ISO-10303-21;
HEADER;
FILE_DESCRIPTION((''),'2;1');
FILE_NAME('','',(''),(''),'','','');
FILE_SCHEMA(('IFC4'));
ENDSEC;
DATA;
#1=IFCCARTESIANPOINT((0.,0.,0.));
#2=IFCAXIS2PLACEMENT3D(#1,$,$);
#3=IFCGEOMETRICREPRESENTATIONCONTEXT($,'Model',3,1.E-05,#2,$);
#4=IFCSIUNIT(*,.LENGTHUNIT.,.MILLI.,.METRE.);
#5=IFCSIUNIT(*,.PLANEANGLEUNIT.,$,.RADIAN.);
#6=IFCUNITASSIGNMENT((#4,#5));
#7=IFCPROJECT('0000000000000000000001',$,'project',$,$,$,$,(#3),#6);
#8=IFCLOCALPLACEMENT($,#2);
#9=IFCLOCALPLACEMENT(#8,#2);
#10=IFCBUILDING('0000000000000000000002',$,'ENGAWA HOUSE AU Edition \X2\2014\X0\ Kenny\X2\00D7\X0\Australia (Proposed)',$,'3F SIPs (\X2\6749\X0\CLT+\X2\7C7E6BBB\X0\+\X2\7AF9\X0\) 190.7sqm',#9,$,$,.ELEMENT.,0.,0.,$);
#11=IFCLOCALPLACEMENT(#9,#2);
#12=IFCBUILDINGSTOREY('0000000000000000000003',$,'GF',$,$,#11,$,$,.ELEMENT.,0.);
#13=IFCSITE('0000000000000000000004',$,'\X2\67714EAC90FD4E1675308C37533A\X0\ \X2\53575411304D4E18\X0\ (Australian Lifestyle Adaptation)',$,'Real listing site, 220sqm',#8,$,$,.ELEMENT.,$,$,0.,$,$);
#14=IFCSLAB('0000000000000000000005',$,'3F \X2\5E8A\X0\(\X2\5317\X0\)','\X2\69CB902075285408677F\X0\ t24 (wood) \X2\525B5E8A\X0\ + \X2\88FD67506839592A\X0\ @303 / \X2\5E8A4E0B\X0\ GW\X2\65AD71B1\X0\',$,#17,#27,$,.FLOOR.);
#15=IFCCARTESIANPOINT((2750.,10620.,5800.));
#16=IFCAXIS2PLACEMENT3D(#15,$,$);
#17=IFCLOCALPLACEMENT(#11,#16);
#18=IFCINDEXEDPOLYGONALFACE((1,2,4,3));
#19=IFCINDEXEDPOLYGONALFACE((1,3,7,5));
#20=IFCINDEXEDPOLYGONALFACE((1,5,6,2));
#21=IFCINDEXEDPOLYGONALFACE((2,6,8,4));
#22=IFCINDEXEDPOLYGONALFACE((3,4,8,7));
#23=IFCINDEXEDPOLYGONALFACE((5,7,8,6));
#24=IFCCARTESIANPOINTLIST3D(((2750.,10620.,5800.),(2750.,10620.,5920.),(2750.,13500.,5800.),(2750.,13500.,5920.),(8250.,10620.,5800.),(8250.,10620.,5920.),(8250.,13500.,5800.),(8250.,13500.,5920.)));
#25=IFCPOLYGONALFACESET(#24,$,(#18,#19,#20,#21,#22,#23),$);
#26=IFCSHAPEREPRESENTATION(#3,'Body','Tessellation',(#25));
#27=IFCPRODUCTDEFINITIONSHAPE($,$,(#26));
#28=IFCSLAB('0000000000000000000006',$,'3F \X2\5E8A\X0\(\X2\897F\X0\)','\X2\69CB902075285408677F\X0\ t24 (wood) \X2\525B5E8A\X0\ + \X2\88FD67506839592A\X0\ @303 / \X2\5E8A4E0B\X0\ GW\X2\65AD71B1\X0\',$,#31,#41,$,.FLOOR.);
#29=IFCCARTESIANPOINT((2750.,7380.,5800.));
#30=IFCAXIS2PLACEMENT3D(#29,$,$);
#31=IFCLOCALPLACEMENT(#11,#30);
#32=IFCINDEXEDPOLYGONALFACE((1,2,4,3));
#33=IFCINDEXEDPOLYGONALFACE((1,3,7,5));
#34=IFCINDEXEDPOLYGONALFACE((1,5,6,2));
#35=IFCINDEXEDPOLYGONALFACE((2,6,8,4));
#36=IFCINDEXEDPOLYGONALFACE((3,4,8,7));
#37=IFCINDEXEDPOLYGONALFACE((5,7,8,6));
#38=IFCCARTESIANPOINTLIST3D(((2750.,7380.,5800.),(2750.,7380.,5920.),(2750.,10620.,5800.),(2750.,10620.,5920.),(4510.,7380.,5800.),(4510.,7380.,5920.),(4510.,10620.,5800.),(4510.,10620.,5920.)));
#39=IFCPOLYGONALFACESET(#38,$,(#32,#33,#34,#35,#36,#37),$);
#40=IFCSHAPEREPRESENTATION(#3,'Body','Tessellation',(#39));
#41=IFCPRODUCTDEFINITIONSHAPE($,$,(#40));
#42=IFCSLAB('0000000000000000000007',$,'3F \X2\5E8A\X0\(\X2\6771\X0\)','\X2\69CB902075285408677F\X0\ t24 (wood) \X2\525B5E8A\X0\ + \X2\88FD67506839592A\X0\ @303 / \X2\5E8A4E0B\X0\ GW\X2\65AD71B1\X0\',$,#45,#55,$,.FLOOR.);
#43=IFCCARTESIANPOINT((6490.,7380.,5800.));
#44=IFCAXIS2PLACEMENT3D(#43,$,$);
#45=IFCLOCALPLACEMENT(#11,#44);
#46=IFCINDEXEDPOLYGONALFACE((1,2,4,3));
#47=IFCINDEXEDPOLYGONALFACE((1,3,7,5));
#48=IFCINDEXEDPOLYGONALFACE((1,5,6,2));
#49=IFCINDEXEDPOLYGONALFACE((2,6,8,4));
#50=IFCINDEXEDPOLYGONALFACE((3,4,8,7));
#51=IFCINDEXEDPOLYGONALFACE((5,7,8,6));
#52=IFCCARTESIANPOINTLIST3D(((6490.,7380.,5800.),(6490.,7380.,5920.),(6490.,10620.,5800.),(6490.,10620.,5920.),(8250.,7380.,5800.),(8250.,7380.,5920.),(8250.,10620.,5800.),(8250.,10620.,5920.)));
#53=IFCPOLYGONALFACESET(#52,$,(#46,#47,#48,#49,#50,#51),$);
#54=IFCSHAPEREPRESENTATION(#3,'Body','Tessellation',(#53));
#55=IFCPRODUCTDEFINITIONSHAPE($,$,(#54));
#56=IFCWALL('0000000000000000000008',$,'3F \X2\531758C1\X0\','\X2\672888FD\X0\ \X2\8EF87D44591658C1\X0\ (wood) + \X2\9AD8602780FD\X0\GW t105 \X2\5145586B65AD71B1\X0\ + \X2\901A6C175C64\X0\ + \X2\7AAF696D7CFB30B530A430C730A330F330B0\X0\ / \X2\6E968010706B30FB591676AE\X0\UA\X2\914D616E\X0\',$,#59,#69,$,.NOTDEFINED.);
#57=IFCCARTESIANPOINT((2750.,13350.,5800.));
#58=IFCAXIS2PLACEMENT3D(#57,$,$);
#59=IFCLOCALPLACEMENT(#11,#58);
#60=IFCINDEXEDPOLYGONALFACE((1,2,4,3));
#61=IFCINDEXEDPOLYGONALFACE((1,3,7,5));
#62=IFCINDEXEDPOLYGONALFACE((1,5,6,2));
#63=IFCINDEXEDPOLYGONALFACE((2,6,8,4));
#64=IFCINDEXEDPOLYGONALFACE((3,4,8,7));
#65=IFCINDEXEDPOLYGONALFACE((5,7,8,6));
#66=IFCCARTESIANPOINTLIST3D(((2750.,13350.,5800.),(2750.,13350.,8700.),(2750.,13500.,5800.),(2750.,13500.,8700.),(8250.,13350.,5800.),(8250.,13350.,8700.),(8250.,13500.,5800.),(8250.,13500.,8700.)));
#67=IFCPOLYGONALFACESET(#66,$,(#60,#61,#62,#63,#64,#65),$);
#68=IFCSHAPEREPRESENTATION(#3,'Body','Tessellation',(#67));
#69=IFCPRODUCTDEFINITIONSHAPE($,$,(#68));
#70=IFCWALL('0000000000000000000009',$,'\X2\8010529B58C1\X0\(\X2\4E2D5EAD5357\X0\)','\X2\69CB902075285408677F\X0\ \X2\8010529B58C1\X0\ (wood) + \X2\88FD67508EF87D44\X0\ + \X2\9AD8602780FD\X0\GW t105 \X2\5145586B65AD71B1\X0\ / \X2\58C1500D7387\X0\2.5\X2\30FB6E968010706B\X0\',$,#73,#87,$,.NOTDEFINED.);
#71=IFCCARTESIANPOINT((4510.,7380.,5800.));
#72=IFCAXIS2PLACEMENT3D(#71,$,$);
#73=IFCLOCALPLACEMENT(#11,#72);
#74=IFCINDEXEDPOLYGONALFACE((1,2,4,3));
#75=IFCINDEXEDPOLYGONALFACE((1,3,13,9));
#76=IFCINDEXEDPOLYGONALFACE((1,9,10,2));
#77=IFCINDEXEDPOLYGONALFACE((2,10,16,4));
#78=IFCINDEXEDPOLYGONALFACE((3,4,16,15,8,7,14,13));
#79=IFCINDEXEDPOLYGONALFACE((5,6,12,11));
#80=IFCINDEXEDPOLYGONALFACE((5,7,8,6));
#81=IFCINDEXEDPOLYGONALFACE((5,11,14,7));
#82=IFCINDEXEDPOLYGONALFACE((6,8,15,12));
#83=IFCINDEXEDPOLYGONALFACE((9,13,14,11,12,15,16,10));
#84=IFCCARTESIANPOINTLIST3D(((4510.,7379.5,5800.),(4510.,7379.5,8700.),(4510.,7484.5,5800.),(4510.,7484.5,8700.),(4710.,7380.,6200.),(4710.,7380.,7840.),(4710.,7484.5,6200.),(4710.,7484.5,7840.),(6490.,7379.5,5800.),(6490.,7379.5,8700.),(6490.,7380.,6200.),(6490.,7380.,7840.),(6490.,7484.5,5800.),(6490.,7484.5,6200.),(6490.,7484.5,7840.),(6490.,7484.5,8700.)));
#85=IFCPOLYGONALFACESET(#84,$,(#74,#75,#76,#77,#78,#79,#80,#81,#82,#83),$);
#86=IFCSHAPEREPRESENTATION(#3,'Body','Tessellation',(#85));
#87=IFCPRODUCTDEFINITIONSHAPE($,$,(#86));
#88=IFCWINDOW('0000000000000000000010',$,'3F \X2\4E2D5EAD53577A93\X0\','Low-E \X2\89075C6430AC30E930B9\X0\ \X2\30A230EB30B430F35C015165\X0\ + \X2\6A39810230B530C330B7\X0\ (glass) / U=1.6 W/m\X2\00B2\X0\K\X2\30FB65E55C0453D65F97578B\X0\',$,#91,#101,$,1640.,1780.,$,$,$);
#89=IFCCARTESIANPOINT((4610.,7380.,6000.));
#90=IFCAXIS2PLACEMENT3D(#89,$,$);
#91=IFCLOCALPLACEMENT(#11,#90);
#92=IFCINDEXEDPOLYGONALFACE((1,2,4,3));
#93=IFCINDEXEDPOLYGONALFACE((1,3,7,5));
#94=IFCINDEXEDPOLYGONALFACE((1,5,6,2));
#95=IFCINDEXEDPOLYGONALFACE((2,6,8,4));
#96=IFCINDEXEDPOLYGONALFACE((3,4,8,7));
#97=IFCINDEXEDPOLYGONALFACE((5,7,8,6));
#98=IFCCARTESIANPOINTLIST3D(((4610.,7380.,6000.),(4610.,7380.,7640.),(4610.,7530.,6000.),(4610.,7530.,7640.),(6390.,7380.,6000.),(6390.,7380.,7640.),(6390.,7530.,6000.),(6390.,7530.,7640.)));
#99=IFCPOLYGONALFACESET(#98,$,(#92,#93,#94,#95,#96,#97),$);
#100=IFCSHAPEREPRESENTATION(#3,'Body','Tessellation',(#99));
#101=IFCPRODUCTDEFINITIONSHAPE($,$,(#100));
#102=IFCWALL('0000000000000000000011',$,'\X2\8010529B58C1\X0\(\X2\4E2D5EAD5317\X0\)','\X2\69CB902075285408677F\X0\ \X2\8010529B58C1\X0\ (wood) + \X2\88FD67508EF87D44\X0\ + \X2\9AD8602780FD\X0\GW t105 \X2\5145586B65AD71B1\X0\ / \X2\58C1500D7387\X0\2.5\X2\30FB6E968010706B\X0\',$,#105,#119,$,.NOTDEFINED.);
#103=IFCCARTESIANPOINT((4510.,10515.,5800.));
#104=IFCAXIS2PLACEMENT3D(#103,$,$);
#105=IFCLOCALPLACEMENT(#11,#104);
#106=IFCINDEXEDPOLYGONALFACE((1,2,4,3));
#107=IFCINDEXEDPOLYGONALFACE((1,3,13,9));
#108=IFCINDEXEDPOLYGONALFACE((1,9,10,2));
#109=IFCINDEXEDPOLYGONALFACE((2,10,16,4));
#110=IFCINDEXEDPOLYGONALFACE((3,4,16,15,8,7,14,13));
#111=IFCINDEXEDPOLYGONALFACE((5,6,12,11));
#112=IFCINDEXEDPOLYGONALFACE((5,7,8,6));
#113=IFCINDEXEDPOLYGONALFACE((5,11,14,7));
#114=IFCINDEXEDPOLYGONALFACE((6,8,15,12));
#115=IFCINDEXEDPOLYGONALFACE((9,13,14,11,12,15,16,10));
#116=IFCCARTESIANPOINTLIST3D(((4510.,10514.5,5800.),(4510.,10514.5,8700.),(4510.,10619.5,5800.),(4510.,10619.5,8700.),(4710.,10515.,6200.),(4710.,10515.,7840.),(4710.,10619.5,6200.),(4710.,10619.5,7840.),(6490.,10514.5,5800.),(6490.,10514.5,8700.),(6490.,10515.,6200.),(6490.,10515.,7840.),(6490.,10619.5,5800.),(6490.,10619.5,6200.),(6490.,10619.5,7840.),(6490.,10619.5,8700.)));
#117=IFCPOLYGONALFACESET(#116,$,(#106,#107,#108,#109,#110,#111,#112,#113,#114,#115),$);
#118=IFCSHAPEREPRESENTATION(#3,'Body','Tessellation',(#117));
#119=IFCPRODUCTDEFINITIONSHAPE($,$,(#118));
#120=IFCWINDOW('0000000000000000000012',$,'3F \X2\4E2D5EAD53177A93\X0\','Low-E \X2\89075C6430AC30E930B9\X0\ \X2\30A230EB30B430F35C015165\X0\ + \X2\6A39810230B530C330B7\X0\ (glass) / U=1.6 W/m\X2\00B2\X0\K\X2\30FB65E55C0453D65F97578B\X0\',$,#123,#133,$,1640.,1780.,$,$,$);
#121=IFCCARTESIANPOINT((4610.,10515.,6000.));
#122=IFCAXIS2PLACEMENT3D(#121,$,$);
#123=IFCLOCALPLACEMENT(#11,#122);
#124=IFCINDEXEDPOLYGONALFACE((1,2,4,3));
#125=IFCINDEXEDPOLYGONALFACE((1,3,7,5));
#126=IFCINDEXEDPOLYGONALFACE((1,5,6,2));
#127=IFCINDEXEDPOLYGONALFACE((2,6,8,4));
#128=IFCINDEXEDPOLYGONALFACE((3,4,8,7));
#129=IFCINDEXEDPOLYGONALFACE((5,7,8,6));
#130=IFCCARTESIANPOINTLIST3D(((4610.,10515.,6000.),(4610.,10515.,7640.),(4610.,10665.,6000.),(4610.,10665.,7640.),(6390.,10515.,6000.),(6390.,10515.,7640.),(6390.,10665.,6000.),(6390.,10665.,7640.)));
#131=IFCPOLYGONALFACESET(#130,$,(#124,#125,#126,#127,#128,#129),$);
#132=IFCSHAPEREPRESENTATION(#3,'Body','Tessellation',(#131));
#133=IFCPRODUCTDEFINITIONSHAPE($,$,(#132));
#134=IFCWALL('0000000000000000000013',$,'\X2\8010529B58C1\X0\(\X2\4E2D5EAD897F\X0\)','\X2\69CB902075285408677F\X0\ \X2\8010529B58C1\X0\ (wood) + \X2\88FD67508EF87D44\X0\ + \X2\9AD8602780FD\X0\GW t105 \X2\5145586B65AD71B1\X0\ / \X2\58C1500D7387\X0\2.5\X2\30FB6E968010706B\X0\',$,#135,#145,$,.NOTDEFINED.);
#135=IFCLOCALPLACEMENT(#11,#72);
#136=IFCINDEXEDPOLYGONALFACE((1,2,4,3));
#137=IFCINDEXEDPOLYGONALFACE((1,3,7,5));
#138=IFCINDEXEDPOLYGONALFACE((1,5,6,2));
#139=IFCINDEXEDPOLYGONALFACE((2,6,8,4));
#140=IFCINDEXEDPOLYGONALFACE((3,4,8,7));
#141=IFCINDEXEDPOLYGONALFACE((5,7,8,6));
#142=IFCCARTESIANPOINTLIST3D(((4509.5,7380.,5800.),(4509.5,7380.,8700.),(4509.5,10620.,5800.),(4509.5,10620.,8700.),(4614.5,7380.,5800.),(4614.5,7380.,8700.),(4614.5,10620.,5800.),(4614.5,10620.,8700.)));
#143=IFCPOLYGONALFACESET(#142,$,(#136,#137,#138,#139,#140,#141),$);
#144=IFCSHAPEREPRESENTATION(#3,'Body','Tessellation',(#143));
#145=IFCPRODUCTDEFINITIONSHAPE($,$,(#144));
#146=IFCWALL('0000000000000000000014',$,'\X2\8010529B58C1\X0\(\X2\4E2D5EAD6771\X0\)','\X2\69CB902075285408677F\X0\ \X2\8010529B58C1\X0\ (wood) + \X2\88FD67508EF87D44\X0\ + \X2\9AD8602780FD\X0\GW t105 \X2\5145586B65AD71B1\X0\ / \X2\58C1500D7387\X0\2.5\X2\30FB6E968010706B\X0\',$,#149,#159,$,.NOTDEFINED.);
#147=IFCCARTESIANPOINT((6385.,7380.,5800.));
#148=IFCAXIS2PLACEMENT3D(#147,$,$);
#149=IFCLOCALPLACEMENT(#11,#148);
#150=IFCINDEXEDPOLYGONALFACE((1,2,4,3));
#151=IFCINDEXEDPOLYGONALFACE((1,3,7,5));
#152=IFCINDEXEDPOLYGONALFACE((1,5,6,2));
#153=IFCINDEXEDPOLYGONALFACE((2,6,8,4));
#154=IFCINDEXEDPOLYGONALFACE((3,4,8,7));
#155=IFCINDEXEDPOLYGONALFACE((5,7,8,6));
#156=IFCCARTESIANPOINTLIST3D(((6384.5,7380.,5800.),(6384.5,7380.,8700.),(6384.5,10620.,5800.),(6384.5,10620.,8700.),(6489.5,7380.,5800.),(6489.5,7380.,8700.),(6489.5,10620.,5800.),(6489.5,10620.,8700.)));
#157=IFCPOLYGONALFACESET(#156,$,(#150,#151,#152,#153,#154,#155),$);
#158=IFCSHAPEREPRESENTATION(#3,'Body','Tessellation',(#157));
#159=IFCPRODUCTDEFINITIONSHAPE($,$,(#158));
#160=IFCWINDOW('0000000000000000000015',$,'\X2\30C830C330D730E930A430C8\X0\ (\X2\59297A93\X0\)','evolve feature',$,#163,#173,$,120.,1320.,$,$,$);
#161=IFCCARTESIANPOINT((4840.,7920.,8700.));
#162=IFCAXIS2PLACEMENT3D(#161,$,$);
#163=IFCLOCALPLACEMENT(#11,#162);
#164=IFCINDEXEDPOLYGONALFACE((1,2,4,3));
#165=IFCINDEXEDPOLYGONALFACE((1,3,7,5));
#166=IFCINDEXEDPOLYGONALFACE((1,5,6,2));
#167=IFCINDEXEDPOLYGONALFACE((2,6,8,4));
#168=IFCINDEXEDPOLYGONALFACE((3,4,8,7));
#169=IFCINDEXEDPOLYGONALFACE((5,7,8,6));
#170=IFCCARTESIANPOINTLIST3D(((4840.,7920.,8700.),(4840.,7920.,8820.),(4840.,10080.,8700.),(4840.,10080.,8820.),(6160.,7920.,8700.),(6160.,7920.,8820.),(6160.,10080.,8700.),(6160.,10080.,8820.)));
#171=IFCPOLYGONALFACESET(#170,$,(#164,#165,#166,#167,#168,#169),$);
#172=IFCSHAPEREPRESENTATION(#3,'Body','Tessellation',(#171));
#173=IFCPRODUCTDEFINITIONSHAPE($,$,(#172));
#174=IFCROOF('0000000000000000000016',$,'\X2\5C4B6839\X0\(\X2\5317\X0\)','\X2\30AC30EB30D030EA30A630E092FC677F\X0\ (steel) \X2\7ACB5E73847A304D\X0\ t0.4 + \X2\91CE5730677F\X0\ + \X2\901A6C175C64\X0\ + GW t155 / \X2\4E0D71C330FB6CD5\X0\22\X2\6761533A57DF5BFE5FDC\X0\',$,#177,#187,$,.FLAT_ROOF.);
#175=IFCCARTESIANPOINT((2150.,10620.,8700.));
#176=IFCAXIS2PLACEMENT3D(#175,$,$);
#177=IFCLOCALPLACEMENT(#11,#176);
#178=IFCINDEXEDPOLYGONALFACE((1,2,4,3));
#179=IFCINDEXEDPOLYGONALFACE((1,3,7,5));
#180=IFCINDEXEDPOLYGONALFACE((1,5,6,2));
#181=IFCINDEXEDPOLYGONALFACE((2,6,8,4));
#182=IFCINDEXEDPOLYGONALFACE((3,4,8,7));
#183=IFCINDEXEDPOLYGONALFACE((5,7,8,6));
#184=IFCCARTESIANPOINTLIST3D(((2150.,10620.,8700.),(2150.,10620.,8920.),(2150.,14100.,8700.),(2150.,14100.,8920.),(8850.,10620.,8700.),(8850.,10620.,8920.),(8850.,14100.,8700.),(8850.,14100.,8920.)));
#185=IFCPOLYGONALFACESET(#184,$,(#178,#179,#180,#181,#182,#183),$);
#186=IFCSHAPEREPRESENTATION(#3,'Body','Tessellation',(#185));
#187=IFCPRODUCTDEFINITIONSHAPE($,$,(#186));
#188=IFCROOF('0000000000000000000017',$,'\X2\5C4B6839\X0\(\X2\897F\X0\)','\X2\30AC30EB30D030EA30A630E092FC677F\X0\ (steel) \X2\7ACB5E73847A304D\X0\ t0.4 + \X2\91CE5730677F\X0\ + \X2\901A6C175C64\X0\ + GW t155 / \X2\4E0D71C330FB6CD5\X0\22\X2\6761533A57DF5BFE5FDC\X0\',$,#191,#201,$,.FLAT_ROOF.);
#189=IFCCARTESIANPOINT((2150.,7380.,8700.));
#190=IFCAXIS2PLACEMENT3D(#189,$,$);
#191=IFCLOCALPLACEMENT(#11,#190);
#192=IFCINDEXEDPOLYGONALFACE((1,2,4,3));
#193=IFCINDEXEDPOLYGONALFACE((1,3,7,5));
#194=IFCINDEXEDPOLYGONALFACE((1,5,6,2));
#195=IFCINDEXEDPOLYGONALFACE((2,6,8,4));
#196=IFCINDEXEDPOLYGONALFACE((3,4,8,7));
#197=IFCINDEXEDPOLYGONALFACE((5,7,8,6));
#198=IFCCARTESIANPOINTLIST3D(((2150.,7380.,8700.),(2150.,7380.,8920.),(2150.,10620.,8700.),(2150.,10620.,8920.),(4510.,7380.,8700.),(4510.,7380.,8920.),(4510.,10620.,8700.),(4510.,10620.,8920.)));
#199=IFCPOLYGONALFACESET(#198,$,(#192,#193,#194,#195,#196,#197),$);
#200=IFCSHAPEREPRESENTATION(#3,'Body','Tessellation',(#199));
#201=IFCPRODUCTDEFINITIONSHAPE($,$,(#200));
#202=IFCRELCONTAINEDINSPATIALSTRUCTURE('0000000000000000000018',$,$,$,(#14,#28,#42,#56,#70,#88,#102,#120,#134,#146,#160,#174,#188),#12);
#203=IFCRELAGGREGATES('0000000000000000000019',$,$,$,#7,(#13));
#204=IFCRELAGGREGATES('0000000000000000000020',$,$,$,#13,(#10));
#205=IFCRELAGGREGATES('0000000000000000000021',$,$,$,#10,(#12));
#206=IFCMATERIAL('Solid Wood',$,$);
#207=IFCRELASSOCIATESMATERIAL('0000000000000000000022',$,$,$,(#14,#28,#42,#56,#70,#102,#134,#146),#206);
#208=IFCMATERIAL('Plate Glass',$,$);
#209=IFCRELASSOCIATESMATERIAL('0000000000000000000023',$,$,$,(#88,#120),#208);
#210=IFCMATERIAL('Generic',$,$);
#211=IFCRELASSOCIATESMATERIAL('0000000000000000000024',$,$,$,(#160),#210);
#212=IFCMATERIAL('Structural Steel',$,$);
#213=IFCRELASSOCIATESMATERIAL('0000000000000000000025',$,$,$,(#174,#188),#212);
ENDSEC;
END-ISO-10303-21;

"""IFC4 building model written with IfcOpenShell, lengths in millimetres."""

from ifc_helpers import new_model, si_unit, frame, frame_2d, origin, place, context, project, spatial, rectangle, extrude, material, element, fill, save


model = new_model("IFC4")

# Units and contexts
model_context = context("Model", 3, precision=1e-05, world=origin())
ifc_project = project(units=[si_unit("LENGTHUNIT", "METRE", prefix="MILLI"), si_unit("PLANEANGLEUNIT", "RADIAN")], contexts=[model_context])

# Site, building, storey
site_placement = place(None, origin())
site = spatial("IfcSite", under=ifc_project, at=site_placement, Name="東京都世田谷区 南向き丘 (Australian Lifestyle Adaptation)", ObjectType="Real listing site, 220sqm", CompositionType="ELEMENT", RefElevation=0.0)
building_placement = place(site_placement, origin())
building = spatial("IfcBuilding", under=site, at=building_placement, Name="ENGAWA HOUSE AU Edition — Kenny×Australia (Proposed)", ObjectType="3F SIPs (杉CLT+籾殻+竹) 190.7sqm", CompositionType="ELEMENT", ElevationOfRefHeight=0.0, ElevationOfTerrain=0.0)
storey_placement = place(building_placement, origin())
storey = spatial("IfcBuildingStorey", under=building, at=storey_placement, Name="GF", CompositionType="ELEMENT", Elevation=0.0)

# Slabs
ifc_material_1 = material(Name="Solid Wood")
slab_1_placement = place(storey_placement, frame((2750.0, 10620.0, 5800.0)))
element("IfcSlab", 1, at=slab_1_placement, inside=storey, material=ifc_material_1, Name="3F 床(北)", Description="構造用合板 t24 (wood) 剛床 + 製材根太 @303 / 床下 GW断熱", PredefinedType="FLOOR", context=model_context, shape_type="SweptSolid", body=[
    extrude(rectangle(XDim=5500.0, YDim=2880.0, at=frame_2d((2750.0, 1440.0))), frame((2750.0, 10620.0, 5800.0)), (0.0, 0.0, 1.0), 120.0),
])
slab_2_placement = place(storey_placement, frame((2750.0, 7380.0, 5800.0)))
element("IfcSlab", 2, at=slab_2_placement, inside=storey, material=ifc_material_1, Name="3F 床(西)", Description="構造用合板 t24 (wood) 剛床 + 製材根太 @303 / 床下 GW断熱", PredefinedType="FLOOR", context=model_context, shape_type="SweptSolid", body=[
    extrude(rectangle(XDim=1760.0, YDim=3240.0, at=frame_2d((880.0, 1620.0))), frame((2750.0, 7380.0, 5800.0)), (0.0, 0.0, 1.0), 120.0),
])
slab_3_placement = place(storey_placement, frame((6490.0, 7380.0, 5800.0)))
element("IfcSlab", 3, at=slab_3_placement, inside=storey, material=ifc_material_1, Name="3F 床(東)", Description="構造用合板 t24 (wood) 剛床 + 製材根太 @303 / 床下 GW断熱", PredefinedType="FLOOR", context=model_context, shape_type="SweptSolid", body=[
    extrude(rectangle(XDim=1760.0, YDim=3240.0, at=frame_2d((880.0, 1620.0))), frame((6490.0, 7380.0, 5800.0)), (0.0, 0.0, 1.0), 120.0),
])

# Wall
wall_1_placement = place(storey_placement, frame((2750.0, 13350.0, 5800.0)))
element("IfcWall", 4, at=wall_1_placement, inside=storey, material=ifc_material_1, Name="3F 北壁", Description="木製 軸組外壁 (wood) + 高性能GW t105 充填断熱 + 通気層 + 窯業系サイディング / 準耐火・外皮UA配慮", PredefinedType="NOTDEFINED", context=model_context, shape_type="SweptSolid", body=[
    extrude(rectangle(XDim=5500.0, YDim=150.0, at=frame_2d((2750.0, 75.0))), frame((2750.0, 13350.0, 5800.0)), (0.0, 0.0, 1.0), 2900.0),
])

# Walls, openings, windows
wall_2_placement = place(storey_placement, frame((4510.0, 7380.0, 5800.0)))
wall_2 = element("IfcWall", 5, at=wall_2_placement, inside=storey, material=ifc_material_1, Name="耐力壁(中庭南)", Description="構造用合板 耐力壁 (wood) + 製材軸組 + 高性能GW t105 充填断熱 / 壁倍率2.5・準耐火", PredefinedType="NOTDEFINED", context=model_context, shape_type="SweptSolid", body=[
    extrude(rectangle(XDim=1980.0, YDim=105.0, at=frame_2d((990.0, 52.0))), frame((4510.0, 7380.0, 5800.0)), (0.0, 0.0, 1.0), 2900.0),
])
opening_1_placement = place(storey_placement, frame((4610.0, 7380.0, 6000.0)))
opening_1 = element("IfcOpeningElement", 6, at=opening_1_placement, cuts=wall_2, PredefinedType="NOTDEFINED", context=model_context, shape_type="SweptSolid", body=[
    extrude(rectangle(XDim=1780.0, YDim=150.0, at=frame_2d((890.0, 75.0))), frame((4610.0, 7380.0, 6000.0)), (0.0, 0.0, 1.0), 1640.0),
])
ifc_material_2 = material(Name="Plate Glass")
window_1_placement = place(storey_placement, frame((4610.0, 7380.0, 6000.0)))
window_1 = element("IfcWindow", 7, at=window_1_placement, inside=storey, material=ifc_material_2, Name="3F 中庭南窓", Description="Low-E 複層ガラス アルゴン封入 + 樹脂サッシ (glass) / U=1.6 W/m²K・日射取得型", OverallHeight=1640.0, OverallWidth=1780.0, context=model_context, shape_type="SweptSolid", body=[
    extrude(rectangle(XDim=1780.0, YDim=150.0, at=frame_2d((890.0, 75.0))), frame((4610.0, 7380.0, 6000.0)), (0.0, 0.0, 1.0), 1640.0),
])
fill(opening_1, window_1)
wall_3_placement = place(storey_placement, frame((4510.0, 10515.0, 5800.0)))
wall_3 = element("IfcWall", 8, at=wall_3_placement, inside=storey, material=ifc_material_1, Name="耐力壁(中庭北)", Description="構造用合板 耐力壁 (wood) + 製材軸組 + 高性能GW t105 充填断熱 / 壁倍率2.5・準耐火", PredefinedType="NOTDEFINED", context=model_context, shape_type="SweptSolid", body=[
    extrude(rectangle(XDim=1980.0, YDim=105.0, at=frame_2d((990.0, 52.0))), frame((4510.0, 10515.0, 5800.0)), (0.0, 0.0, 1.0), 2900.0),
])
opening_2_placement = place(storey_placement, frame((4610.0, 10515.0, 6000.0)))
opening_2 = element("IfcOpeningElement", 9, at=opening_2_placement, cuts=wall_3, PredefinedType="NOTDEFINED", context=model_context, shape_type="SweptSolid", body=[
    extrude(rectangle(XDim=1780.0, YDim=150.0, at=frame_2d((890.0, 75.0))), frame((4610.0, 10515.0, 6000.0)), (0.0, 0.0, 1.0), 1640.0),
])
window_2_placement = place(storey_placement, frame((4610.0, 10515.0, 6000.0)))
window_2 = element("IfcWindow", 10, at=window_2_placement, inside=storey, material=ifc_material_2, Name="3F 中庭北窓", Description="Low-E 複層ガラス アルゴン封入 + 樹脂サッシ (glass) / U=1.6 W/m²K・日射取得型", OverallHeight=1640.0, OverallWidth=1780.0, context=model_context, shape_type="SweptSolid", body=[
    extrude(rectangle(XDim=1780.0, YDim=150.0, at=frame_2d((890.0, 75.0))), frame((4610.0, 10515.0, 6000.0)), (0.0, 0.0, 1.0), 1640.0),
])
fill(opening_2, window_2)

# Walls
wall_4_placement = place(storey_placement, frame((4510.0, 7380.0, 5800.0)))
element("IfcWall", 11, at=wall_4_placement, inside=storey, material=ifc_material_1, Name="耐力壁(中庭西)", Description="構造用合板 耐力壁 (wood) + 製材軸組 + 高性能GW t105 充填断熱 / 壁倍率2.5・準耐火", PredefinedType="NOTDEFINED", context=model_context, shape_type="SweptSolid", body=[
    extrude(rectangle(XDim=105.0, YDim=3240.0, at=frame_2d((52.0, 1620.0))), frame((4510.0, 7380.0, 5800.0)), (0.0, 0.0, 1.0), 2900.0),
])
wall_5_placement = place(storey_placement, frame((6385.0, 7380.0, 5800.0)))
element("IfcWall", 12, at=wall_5_placement, inside=storey, material=ifc_material_1, Name="耐力壁(中庭東)", Description="構造用合板 耐力壁 (wood) + 製材軸組 + 高性能GW t105 充填断熱 / 壁倍率2.5・準耐火", PredefinedType="NOTDEFINED", context=model_context, shape_type="SweptSolid", body=[
    extrude(rectangle(XDim=105.0, YDim=3240.0, at=frame_2d((52.0, 1620.0))), frame((6385.0, 7380.0, 5800.0)), (0.0, 0.0, 1.0), 2900.0),
])

# Window
ifc_material_3 = material(Name="Generic")
window_3_placement = place(storey_placement, frame((4840.0, 7920.0, 8700.0)))
element("IfcWindow", 13, at=window_3_placement, inside=storey, material=ifc_material_3, Name="トップライト (天窓)", Description="evolve feature", OverallHeight=120.0, OverallWidth=1320.0, context=model_context, shape_type="SweptSolid", body=[
    extrude(rectangle(XDim=1320.0, YDim=2160.0, at=frame_2d((660.0, 1080.0))), frame((4840.0, 7920.0, 8700.0)), (0.0, 0.0, 1.0), 120.0),
])

# Roofs
ifc_material_4 = material(Name="Structural Steel")
for number, where, name in (
    (14, (2150.0, 10620.0, 8700.0), "屋根(北)"),
):
    element("IfcRoof", number, at=place(storey_placement, frame(where)), inside=storey, material=ifc_material_4, Name=name, Description="ガルバリウム鋼板 (steel) 立平葺き t0.4 + 野地板 + 通気層 + GW t155 / 不燃・法22条区域対応", PredefinedType="FLAT_ROOF", context=model_context, shape_type="SweptSolid", body=[
        extrude(rectangle(XDim=6700.0, YDim=3480.0, at=frame_2d((3350.0, 1740.0))), frame((2150.0, 10620.0, 8700.0)), (0.0, 0.0, 1.0), 220.0),
    ])
roof_1_placement = place(storey_placement, frame((2150.0, 7380.0, 8700.0)))
element("IfcRoof", 15, at=roof_1_placement, inside=storey, material=ifc_material_4, Name="屋根(西)", Description="ガルバリウム鋼板 (steel) 立平葺き t0.4 + 野地板 + 通気層 + GW t155 / 不燃・法22条区域対応", PredefinedType="FLAT_ROOF", context=model_context, shape_type="SweptSolid", body=[
    extrude(rectangle(XDim=2360.0, YDim=3240.0, at=frame_2d((1180.0, 1620.0))), frame((2150.0, 7380.0, 8700.0)), (0.0, 0.0, 1.0), 220.0),
])

save(model, "model.ifc")
